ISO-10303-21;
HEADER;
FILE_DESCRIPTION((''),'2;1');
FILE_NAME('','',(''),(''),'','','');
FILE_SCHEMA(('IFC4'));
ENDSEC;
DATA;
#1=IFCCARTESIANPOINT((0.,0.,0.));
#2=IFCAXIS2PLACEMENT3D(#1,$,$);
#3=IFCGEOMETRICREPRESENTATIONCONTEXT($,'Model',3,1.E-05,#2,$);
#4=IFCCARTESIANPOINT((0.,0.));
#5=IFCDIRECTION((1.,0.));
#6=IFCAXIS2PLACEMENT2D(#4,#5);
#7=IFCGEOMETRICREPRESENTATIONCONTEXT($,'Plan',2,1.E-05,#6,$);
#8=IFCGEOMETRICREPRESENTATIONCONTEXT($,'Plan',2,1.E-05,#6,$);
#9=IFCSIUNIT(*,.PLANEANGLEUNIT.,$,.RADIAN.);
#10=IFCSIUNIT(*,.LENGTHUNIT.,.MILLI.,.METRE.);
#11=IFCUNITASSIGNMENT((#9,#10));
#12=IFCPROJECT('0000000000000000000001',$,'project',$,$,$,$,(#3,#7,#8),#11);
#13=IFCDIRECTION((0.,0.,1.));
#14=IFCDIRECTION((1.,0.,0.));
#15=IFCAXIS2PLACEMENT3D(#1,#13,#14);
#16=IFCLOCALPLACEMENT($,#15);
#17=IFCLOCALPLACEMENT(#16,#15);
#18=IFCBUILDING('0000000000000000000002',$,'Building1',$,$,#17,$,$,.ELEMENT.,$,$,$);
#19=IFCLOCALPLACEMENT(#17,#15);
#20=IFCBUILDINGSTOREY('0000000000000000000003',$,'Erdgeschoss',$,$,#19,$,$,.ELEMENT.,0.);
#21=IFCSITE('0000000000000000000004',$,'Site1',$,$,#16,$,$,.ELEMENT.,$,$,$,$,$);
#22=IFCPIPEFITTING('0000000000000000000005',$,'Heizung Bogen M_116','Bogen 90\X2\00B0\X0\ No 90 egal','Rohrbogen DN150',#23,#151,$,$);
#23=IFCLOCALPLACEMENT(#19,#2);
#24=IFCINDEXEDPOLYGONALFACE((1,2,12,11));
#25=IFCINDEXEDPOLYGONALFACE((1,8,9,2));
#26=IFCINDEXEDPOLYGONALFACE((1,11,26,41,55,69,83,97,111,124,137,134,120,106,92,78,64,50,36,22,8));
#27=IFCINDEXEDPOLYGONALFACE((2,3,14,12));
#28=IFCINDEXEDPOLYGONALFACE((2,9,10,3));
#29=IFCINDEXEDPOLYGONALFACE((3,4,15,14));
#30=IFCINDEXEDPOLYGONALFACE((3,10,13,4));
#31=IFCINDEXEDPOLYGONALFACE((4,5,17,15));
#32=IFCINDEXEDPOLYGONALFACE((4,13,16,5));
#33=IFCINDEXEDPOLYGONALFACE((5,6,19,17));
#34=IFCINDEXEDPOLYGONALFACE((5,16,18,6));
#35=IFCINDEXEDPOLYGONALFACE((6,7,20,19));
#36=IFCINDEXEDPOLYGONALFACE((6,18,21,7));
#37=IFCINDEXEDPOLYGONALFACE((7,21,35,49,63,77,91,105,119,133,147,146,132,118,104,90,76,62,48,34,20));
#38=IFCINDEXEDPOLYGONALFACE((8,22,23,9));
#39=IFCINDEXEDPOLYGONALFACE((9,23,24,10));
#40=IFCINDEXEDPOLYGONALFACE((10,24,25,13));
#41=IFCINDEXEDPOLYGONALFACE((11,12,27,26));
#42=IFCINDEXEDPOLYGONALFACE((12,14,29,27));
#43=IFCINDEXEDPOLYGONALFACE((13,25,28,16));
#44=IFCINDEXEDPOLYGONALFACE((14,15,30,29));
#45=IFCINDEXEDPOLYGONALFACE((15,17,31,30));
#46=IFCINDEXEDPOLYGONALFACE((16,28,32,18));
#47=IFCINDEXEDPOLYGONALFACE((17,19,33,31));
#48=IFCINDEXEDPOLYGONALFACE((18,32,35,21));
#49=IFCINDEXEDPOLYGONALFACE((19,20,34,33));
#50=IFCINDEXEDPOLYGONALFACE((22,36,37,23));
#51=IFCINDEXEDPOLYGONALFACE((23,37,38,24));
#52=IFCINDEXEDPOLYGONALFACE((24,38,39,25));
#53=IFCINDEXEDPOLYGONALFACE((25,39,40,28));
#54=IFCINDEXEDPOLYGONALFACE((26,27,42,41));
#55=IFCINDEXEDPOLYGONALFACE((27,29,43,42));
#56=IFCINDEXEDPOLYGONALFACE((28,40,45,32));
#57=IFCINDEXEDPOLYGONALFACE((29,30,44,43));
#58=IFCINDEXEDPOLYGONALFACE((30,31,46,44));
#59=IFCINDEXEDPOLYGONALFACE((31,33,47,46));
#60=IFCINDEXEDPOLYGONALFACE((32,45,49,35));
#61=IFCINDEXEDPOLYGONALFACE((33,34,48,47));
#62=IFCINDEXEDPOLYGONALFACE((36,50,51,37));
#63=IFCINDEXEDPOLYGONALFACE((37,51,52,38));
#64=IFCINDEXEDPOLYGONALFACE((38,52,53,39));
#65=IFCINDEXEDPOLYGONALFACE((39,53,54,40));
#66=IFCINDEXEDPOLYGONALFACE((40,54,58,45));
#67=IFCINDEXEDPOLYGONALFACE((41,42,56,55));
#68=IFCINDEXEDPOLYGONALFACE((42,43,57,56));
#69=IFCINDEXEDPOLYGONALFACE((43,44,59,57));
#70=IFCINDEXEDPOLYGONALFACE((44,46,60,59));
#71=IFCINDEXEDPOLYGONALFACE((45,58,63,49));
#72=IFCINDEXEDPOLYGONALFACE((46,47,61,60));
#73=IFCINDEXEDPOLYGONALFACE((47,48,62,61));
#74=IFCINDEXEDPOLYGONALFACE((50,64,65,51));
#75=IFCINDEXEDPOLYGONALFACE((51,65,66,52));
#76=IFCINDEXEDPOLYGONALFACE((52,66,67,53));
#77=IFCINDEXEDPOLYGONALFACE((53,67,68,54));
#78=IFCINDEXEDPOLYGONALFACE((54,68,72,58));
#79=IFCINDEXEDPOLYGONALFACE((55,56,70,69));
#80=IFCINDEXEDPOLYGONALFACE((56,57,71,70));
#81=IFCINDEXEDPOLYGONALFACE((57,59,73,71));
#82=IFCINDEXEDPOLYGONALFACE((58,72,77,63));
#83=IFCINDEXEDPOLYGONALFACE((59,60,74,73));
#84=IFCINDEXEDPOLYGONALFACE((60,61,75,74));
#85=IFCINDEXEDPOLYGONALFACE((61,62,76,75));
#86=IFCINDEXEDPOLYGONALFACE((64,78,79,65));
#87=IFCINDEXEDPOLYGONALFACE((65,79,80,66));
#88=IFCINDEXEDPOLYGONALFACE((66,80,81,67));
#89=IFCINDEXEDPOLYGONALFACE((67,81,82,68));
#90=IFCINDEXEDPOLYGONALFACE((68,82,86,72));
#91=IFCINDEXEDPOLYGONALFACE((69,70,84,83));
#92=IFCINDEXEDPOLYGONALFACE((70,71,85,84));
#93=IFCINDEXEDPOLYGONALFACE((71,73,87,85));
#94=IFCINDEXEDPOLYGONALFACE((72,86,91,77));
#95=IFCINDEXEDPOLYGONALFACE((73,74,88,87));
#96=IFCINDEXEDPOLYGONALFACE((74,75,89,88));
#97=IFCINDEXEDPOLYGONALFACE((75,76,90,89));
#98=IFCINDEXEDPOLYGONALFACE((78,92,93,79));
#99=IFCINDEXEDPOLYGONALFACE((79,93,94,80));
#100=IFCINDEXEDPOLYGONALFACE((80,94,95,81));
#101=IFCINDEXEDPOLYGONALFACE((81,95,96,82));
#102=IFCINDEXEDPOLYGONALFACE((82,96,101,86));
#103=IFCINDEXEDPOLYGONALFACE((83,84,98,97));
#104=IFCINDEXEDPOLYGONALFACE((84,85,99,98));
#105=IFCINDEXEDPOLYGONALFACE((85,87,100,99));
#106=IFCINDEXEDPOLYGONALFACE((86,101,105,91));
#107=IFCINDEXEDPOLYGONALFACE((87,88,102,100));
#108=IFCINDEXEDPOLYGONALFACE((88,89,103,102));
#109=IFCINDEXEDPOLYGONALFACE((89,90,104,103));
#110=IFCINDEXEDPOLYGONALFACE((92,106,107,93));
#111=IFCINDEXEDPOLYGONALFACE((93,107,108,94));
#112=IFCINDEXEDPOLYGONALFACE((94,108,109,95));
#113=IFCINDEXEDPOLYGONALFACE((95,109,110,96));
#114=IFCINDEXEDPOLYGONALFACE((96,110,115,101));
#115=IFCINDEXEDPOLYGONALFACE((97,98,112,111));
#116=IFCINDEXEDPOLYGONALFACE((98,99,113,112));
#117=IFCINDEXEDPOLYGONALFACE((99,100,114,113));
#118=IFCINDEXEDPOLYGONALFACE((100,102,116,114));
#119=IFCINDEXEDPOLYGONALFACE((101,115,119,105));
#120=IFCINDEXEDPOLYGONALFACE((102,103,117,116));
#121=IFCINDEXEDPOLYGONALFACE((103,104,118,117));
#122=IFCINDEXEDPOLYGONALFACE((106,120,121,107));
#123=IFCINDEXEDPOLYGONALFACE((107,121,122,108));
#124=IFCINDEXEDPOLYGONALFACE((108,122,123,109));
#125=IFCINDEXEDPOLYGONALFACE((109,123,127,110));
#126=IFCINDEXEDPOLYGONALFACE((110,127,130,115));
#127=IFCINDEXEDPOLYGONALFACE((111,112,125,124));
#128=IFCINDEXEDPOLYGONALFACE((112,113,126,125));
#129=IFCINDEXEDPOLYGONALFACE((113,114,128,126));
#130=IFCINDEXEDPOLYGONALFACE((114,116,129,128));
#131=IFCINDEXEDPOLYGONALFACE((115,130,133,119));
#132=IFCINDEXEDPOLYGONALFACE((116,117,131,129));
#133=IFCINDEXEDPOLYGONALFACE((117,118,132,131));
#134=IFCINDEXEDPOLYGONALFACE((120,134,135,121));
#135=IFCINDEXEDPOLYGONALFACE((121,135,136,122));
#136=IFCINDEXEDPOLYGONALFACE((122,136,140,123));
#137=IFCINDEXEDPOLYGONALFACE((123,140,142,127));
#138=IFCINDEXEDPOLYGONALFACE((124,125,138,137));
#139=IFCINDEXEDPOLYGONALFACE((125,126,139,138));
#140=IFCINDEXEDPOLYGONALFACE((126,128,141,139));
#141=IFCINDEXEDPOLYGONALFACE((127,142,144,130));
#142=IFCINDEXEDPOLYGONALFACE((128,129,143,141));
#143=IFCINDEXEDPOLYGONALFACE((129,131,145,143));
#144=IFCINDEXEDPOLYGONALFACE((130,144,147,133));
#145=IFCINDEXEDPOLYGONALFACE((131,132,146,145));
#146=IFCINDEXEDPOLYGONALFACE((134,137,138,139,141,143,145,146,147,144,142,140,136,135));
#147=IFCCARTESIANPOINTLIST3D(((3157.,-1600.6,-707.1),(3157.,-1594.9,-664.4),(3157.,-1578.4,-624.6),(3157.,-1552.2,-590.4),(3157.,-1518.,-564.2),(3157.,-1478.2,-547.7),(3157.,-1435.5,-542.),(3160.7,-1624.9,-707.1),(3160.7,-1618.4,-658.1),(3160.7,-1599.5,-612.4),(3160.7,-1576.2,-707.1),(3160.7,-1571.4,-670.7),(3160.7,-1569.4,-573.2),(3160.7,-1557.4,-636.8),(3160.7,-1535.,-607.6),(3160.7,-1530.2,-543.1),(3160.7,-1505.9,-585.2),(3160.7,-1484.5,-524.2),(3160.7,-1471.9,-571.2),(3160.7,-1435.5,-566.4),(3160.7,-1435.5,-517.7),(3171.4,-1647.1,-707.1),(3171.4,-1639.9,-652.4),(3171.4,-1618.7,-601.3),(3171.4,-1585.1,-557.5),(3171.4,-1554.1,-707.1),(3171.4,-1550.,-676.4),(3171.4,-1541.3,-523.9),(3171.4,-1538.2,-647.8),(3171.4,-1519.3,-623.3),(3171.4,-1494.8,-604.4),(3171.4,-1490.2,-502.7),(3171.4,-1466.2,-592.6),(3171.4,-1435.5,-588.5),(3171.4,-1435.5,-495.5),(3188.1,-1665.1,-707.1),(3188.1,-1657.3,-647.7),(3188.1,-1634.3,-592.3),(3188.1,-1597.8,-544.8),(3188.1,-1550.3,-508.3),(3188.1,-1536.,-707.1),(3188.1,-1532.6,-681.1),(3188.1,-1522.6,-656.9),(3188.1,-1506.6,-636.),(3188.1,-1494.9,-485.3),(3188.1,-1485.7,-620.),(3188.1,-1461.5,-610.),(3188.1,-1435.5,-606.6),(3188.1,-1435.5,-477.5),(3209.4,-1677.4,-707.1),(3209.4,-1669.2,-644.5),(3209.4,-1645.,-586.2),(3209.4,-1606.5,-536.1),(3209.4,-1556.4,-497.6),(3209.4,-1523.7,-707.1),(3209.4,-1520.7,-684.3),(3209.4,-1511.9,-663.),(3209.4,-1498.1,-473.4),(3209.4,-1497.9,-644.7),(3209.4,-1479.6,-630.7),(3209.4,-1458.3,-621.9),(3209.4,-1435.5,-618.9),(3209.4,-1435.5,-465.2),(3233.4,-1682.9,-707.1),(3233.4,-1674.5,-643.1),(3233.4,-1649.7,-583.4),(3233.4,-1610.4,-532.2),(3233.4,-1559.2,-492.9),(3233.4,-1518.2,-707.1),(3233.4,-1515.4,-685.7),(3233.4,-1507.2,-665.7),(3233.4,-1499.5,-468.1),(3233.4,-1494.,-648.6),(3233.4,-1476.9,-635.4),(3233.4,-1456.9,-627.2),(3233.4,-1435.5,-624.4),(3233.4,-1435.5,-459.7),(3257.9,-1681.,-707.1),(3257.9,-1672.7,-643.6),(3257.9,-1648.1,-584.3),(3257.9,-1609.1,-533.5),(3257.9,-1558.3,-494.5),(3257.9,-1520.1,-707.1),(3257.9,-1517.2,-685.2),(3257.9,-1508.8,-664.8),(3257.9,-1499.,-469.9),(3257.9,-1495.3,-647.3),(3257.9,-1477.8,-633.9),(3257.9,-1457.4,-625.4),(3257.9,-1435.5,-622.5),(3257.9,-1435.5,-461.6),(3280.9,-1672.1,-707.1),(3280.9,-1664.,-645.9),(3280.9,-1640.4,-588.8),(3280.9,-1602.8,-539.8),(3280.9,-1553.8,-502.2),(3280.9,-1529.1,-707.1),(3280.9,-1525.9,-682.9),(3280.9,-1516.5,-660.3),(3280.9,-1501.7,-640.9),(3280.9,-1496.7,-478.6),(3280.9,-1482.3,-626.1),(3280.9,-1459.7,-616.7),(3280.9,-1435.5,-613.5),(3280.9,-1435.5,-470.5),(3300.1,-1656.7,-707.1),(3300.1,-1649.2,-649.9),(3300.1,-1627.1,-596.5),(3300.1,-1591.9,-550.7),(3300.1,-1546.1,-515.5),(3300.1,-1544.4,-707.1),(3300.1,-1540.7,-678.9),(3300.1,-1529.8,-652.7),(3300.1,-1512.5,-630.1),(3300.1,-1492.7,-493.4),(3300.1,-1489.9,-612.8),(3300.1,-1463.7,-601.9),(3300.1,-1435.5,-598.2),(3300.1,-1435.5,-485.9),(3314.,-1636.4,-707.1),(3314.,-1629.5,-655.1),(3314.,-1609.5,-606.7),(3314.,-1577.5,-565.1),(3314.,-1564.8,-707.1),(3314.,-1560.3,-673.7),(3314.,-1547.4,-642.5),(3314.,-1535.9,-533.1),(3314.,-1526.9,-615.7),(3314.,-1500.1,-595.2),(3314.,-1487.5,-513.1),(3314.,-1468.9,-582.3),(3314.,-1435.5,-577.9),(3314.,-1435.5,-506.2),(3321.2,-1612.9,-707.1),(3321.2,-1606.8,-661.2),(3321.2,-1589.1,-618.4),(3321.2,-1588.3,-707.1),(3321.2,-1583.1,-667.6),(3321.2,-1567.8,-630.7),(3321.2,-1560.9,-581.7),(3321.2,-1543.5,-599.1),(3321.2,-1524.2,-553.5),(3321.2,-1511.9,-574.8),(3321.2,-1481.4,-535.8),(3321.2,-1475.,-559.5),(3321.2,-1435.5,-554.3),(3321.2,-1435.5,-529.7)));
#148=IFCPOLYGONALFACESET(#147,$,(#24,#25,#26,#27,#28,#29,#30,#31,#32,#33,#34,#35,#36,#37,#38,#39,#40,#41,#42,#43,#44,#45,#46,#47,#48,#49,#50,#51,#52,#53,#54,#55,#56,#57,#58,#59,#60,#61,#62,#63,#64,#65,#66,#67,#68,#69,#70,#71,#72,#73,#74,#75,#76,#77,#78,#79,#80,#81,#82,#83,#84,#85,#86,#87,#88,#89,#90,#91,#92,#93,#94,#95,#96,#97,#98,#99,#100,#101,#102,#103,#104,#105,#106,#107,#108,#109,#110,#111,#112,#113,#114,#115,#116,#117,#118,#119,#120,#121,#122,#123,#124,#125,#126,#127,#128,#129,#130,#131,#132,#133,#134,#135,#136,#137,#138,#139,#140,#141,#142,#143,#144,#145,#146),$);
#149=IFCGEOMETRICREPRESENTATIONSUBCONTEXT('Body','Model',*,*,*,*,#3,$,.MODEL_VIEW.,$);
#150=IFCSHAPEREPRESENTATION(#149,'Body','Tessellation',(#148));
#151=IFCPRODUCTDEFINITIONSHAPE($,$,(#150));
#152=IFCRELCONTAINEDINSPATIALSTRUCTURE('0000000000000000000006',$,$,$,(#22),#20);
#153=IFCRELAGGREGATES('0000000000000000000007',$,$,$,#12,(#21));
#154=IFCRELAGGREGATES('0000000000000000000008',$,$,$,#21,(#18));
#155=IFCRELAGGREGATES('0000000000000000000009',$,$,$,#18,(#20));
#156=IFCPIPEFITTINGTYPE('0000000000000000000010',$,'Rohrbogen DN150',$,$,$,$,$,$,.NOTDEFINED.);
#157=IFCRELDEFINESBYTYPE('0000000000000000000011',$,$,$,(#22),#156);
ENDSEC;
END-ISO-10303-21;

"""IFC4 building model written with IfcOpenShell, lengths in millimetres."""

from ifc_helpers import new_model, entity, si_unit, frame, origin, origin_with_axes, origin_2d_with_axis, place, context, subcontext, project, spatial, source, transform, mapped, type_object, element, save


model = new_model("IFC4")

# Units and contexts
model_context = context("Model", 3, precision=1e-05, world=origin())
plan_context_1 = context("Plan", 2, precision=1e-05, world=origin_2d_with_axis())
plan_context_2 = context("Plan", 2, precision=1e-05, world=origin_2d_with_axis())
body_context = subcontext(model_context, "Body", "Model", "MODEL_VIEW")
ifc_project = project(units=[si_unit("PLANEANGLEUNIT", "RADIAN"), si_unit("LENGTHUNIT", "METRE", prefix="MILLI")], contexts=[model_context, plan_context_1, plan_context_2])

# Site, building, storey
site_placement = place(None, origin_with_axes())
site = spatial("IfcSite", under=ifc_project, at=site_placement, Name="Site1", CompositionType="ELEMENT")
building_placement = place(site_placement, origin_with_axes())
building = spatial("IfcBuilding", under=site, at=building_placement, Name="Building1", CompositionType="ELEMENT")
storey_placement = place(building_placement, origin_with_axes())
storey = spatial("IfcBuildingStorey", under=building, at=storey_placement, Name="Erdgeschoss", CompositionType="ELEMENT", Elevation=0.0)

# Pipe fitting
pipe_fitting_type_1 = type_object("IfcPipeFittingType", Name="Rohrbogen DN150", PredefinedType="NOTDEFINED")
shared_shape_1 = source(origin_with_axes(), body_context, "Body", "SolidModel", [
    entity("IfcRevolvedAreaSolid", entity("IfcCircleProfileDef", "AREA", None, entity("IfcAxis2Placement2D", entity("IfcCartesianPoint", [0.0, 0.0]), entity("IfcDirection", [1.0, 0.0])), 82.5), entity("IfcAxis2Placement3D", entity("IfcCartesianPoint", [-123.8, 0.0, 41.3]), entity("IfcDirection", [1.0, 0.0, 0.0]), entity("IfcDirection", [0.0, -1.0, 0.0])), entity("IfcAxis1Placement", entity("IfcCartesianPoint", [0.0, 165.1, 0.0]), entity("IfcDirection", [-1.0, 0.0, 0.0])), 1.570796),
])
pipe_fitting_1_placement = place(storey_placement, frame((3239.6, -1559.3, -583.3), z_axis=(0.0, 0.0, 1.0), x_axis=(1.0, 0.0, 0.0)))
element("IfcPipeFitting", 1, at=pipe_fitting_1_placement, inside=storey, type_object=pipe_fitting_type_1, Name="Heizung Bogen M_116", Description="Bogen 90° No 90 egal", ObjectType="Rohrbogen DN150", context=body_context, shape_type="MappedRepresentation", body=[
    mapped(shared_shape_1, transform((0.0, 0.0, 0.0), x_axis=(0.0, -1.0, 0.0), y_axis=(1.0, 0.0, 0.0), z_axis=(0.0, 0.0, 1.0), scale=1.0)),
])

save(model, "model.ifc")
